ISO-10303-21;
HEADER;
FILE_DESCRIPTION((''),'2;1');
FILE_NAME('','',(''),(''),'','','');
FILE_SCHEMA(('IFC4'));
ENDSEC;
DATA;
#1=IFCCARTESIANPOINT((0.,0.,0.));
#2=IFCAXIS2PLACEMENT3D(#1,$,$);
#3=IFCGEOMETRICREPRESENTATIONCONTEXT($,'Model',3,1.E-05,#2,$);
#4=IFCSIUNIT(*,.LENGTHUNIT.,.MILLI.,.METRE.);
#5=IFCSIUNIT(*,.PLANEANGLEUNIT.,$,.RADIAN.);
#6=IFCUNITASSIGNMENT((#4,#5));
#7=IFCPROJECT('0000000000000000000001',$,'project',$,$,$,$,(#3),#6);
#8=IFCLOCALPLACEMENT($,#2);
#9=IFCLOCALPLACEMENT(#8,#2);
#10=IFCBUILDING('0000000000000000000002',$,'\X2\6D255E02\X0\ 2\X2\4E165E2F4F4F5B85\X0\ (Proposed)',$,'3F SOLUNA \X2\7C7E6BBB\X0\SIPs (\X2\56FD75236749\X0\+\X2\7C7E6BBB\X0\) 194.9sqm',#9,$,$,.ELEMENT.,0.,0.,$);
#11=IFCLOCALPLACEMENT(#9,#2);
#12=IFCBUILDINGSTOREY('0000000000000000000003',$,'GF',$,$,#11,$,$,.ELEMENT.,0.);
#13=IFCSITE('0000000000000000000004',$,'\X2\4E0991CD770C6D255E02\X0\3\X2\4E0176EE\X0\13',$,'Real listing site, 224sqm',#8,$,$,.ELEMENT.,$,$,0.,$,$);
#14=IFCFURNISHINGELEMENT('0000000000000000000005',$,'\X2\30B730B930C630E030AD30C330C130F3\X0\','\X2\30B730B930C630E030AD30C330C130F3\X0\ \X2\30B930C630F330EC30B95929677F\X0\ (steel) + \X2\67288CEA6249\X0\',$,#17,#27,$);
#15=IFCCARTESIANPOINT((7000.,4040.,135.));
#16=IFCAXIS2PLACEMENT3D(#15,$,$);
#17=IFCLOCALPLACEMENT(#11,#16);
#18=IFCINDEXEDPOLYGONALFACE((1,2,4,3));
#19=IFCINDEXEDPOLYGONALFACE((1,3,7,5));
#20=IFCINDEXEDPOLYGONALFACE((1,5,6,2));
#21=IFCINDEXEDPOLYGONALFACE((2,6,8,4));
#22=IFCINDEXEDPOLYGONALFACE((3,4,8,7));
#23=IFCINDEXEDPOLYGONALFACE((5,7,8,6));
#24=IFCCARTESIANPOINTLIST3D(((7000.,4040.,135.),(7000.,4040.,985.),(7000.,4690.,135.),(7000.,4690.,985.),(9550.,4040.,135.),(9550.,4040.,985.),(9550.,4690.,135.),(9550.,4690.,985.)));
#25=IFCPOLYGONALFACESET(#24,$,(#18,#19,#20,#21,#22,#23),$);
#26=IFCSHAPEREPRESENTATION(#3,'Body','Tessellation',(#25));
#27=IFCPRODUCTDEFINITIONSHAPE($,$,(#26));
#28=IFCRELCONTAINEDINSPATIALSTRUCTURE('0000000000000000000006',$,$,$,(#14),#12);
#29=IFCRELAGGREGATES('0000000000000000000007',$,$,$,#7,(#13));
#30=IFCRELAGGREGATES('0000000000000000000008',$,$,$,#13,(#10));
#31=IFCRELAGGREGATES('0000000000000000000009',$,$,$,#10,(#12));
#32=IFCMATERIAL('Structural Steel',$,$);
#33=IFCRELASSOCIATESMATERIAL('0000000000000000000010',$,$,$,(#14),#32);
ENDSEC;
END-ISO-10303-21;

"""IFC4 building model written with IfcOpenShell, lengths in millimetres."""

from ifc_helpers import new_model, si_unit, frame, frame_2d, origin, place, context, project, spatial, rectangle, extrude, material, element, save


model = new_model("IFC4")

# Units and contexts
model_context = context("Model", 3, precision=1e-05, world=origin())
ifc_project = project(units=[si_unit("LENGTHUNIT", "METRE", prefix="MILLI"), si_unit("PLANEANGLEUNIT", "RADIAN")], contexts=[model_context])

# Site, building, storey
site_placement = place(None, origin())
site = spatial("IfcSite", under=ifc_project, at=site_placement, Name="三重県津市3丁目13", ObjectType="Real listing site, 224sqm", CompositionType="ELEMENT", RefElevation=0.0)
building_placement = place(site_placement, origin())
building = spatial("IfcBuilding", under=site, at=building_placement, Name="津市 2世帯住宅 (Proposed)", ObjectType="3F SOLUNA 籾殻SIPs (国産杉+籾殻) 194.9sqm", CompositionType="ELEMENT", ElevationOfRefHeight=0.0, ElevationOfTerrain=0.0)
storey_placement = place(building_placement, origin())
storey = spatial("IfcBuildingStorey", under=building, at=storey_placement, Name="GF", CompositionType="ELEMENT", Elevation=0.0)

# Furnishing element
ifc_material_1 = material(Name="Structural Steel")
furnishing_1_placement = place(storey_placement, frame((7000.0, 4040.0, 135.0)))
element("IfcFurnishingElement", 1, at=furnishing_1_placement, inside=storey, material=ifc_material_1, Name="システムキッチン", Description="システムキッチン ステンレス天板 (steel) + 木質扉", context=model_context, shape_type="SweptSolid", body=[
    extrude(rectangle(XDim=2550.0, YDim=650.0, at=frame_2d((1275.0, 325.0))), frame((7000.0, 4040.0, 135.0)), (0.0, 0.0, 1.0), 850.0),
])

save(model, "model.ifc")
